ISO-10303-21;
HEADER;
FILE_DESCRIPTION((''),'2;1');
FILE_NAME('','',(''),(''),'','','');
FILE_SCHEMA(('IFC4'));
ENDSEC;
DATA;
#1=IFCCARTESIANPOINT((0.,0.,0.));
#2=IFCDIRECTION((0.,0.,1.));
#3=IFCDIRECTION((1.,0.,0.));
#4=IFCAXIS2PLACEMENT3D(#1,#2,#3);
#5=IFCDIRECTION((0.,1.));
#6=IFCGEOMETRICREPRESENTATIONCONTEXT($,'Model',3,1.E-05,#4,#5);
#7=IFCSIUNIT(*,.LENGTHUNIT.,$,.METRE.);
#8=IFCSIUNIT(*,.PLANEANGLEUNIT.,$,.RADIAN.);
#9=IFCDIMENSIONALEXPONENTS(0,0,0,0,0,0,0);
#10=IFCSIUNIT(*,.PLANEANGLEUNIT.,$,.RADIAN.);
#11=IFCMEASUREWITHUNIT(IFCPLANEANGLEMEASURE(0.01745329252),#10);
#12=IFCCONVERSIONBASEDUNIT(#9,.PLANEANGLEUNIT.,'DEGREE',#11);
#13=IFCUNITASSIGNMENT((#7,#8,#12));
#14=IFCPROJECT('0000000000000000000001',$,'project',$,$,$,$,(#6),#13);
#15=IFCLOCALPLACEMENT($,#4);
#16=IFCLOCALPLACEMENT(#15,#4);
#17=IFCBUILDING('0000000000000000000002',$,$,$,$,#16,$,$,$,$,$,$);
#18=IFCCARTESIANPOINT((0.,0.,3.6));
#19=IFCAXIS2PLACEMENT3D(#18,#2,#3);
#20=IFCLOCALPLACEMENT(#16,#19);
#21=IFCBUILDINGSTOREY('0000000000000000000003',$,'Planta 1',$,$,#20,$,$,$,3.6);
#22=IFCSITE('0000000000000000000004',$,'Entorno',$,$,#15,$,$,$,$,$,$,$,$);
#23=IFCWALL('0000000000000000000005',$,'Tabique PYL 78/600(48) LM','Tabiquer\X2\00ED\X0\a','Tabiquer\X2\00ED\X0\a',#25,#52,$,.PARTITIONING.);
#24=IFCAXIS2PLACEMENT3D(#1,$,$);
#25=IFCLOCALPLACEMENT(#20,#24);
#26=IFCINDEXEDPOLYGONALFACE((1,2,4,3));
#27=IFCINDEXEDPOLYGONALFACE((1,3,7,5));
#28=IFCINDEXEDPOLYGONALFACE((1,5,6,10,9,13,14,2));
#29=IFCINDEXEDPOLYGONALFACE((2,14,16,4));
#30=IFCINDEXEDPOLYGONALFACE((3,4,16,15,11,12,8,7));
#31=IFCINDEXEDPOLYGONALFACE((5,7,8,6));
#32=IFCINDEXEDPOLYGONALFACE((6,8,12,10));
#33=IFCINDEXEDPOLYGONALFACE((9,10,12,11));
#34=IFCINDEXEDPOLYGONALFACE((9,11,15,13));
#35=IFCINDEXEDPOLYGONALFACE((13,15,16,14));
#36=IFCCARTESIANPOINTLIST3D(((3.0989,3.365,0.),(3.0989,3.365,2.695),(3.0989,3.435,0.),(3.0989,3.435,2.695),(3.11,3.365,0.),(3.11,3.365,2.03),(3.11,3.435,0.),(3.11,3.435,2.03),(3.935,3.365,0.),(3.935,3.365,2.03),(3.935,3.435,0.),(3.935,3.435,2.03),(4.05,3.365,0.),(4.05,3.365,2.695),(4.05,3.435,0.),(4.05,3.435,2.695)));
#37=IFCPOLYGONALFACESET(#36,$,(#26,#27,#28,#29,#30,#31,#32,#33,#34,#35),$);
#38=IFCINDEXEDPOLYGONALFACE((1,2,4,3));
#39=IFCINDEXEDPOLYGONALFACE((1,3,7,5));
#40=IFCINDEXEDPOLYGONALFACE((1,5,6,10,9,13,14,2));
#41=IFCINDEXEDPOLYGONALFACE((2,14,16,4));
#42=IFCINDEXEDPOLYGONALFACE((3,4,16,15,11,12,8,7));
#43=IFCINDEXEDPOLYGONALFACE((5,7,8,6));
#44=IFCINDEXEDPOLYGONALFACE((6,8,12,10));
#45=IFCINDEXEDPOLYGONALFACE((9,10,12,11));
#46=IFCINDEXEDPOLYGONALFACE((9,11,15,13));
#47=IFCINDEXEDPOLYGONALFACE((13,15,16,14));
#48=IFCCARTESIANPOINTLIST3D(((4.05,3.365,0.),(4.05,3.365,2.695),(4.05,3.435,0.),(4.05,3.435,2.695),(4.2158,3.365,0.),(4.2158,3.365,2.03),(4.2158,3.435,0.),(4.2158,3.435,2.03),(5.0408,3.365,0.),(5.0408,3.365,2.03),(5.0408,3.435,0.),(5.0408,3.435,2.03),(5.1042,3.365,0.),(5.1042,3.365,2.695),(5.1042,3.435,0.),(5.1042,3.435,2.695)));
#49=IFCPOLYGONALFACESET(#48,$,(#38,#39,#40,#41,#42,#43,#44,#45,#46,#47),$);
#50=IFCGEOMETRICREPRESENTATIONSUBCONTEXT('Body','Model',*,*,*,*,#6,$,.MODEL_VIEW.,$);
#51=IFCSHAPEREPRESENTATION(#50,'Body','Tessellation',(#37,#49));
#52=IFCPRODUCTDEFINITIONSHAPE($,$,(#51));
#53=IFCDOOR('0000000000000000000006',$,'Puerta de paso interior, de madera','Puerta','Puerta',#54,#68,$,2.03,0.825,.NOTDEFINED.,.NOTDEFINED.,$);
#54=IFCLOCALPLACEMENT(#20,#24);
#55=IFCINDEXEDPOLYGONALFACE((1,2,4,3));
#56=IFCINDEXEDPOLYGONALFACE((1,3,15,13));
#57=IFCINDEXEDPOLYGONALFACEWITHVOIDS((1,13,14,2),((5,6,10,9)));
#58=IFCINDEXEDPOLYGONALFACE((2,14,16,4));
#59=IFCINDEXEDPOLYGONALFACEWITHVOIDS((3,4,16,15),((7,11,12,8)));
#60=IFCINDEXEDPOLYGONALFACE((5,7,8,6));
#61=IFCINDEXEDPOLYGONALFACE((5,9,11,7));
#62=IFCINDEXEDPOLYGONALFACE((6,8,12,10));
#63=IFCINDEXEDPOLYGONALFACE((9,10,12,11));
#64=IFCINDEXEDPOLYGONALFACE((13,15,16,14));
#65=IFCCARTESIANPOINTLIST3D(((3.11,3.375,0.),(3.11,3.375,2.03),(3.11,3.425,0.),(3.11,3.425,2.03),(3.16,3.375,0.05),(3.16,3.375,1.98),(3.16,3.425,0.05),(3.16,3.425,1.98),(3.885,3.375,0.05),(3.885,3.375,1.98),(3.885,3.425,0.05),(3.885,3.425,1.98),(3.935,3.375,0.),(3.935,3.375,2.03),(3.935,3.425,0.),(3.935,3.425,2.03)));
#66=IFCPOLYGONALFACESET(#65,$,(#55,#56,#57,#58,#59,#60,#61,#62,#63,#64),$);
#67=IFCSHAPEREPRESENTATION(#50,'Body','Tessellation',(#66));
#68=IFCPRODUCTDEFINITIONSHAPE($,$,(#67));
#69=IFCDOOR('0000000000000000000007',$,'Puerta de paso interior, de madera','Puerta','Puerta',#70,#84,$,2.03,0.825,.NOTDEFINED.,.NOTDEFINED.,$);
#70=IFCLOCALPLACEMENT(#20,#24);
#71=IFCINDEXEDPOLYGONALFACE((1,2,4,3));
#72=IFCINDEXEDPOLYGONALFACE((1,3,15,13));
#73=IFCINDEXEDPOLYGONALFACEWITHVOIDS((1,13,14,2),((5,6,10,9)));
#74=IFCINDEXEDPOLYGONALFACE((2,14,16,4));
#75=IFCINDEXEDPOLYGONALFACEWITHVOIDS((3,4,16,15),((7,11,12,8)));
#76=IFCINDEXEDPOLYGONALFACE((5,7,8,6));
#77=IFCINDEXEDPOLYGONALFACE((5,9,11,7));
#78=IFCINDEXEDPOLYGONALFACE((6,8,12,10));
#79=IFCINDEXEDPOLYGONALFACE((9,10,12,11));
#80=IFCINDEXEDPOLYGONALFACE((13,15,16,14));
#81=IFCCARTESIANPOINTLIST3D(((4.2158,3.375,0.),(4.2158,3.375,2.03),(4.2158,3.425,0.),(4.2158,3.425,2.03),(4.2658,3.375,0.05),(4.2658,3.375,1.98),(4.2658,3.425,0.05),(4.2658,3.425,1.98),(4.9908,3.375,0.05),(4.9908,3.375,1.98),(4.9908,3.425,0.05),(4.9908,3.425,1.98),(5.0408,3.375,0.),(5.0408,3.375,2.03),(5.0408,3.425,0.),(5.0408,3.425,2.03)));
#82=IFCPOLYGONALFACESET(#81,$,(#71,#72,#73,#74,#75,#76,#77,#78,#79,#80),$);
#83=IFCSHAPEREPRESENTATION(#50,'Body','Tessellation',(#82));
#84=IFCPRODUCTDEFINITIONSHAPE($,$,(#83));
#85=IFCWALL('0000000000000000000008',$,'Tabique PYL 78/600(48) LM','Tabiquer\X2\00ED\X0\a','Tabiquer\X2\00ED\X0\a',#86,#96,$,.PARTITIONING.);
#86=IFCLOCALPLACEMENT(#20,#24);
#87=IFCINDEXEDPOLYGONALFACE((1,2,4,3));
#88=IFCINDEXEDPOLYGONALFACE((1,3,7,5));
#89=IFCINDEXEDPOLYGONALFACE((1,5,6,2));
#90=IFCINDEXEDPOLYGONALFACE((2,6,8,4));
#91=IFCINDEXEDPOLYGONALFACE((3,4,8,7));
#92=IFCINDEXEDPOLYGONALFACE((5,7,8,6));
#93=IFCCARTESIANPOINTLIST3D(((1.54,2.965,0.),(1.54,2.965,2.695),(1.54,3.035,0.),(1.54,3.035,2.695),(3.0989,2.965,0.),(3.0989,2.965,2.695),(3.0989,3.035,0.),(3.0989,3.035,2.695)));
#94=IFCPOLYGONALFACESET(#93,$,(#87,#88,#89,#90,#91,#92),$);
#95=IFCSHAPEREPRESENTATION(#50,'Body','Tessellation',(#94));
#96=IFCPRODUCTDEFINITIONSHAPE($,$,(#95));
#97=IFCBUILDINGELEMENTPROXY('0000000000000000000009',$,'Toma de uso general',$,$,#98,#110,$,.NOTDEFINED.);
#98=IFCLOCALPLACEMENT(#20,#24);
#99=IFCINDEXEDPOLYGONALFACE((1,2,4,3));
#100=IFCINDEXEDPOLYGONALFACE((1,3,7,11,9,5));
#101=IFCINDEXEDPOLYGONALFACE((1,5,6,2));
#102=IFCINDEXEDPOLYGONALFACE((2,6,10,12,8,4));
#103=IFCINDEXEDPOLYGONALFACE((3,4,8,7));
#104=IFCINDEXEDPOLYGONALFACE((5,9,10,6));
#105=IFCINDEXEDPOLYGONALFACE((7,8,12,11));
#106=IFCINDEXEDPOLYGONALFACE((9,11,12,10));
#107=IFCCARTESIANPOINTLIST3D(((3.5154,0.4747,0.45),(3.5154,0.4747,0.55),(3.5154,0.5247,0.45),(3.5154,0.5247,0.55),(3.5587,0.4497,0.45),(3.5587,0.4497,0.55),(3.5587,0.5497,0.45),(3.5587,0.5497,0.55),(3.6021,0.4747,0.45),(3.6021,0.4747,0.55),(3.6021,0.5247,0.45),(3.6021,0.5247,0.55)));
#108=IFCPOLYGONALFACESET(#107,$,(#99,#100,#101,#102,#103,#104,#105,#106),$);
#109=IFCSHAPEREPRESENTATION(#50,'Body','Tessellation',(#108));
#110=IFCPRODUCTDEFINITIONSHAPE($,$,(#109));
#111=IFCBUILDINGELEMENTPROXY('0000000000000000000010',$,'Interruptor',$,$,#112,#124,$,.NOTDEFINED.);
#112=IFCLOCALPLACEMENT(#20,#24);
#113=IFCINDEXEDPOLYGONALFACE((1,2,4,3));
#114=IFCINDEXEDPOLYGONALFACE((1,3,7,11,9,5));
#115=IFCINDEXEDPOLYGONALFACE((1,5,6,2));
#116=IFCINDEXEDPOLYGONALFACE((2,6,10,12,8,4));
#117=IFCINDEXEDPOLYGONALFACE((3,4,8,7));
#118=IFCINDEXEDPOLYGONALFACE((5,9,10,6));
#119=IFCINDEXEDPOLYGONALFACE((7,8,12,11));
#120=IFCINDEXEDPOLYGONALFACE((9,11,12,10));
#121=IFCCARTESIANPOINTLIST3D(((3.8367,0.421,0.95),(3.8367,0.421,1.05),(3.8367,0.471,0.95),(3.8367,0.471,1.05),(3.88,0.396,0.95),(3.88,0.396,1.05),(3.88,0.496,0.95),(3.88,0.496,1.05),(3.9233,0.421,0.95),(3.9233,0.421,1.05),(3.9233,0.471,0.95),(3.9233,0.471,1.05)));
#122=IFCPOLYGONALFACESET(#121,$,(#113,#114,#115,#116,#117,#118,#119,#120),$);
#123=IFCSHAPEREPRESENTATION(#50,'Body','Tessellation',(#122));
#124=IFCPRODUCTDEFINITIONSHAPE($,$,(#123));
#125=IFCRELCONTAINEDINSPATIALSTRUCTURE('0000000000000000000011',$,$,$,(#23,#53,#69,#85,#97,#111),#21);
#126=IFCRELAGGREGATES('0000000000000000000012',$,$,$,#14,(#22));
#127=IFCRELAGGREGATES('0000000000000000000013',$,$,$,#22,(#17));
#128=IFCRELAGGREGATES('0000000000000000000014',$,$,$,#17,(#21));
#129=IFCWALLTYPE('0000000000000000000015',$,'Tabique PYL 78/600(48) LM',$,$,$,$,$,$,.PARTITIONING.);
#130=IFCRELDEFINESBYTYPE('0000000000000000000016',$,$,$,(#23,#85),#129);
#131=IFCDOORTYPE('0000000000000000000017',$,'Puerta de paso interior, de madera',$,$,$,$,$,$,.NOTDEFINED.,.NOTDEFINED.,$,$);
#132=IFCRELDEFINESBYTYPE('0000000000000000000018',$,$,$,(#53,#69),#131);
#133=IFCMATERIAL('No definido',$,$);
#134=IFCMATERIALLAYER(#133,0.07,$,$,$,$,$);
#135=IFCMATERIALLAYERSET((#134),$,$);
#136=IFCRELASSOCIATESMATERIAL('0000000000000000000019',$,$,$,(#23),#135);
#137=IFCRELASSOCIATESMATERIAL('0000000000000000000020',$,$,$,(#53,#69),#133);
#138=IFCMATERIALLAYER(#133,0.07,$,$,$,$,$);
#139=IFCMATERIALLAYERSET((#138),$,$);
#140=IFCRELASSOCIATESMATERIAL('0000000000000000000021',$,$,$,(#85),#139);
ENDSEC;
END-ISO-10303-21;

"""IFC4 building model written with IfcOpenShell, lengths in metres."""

from ifc_helpers import new_model, entity, si_unit, converted_unit, direction, frame, origin_with_axes, origin_2d_with_axis, place, context, subcontext, project, spatial, polyline, rectangle, hollow_rectangle, outline, extrude, shape, source, transform, mapped, material, layer, layer_set, layer_usage, type_object, element, fill, save


model = new_model("IFC4")

# Units and contexts
model_context = context("Model", 3, precision=1e-05, world=origin_with_axes(), true_north=direction((0.0, 1.0)))
body_context = subcontext(model_context, "Body", "Model", "MODEL_VIEW")
footprint_context = subcontext(model_context, "FootPrint", "Model", "MODEL_VIEW")
ifc_project = project(units=[si_unit("LENGTHUNIT", "METRE"), si_unit("PLANEANGLEUNIT", "RADIAN"), converted_unit("PLANEANGLEUNIT", "DEGREE", entity("IfcPlaneAngleMeasure", 0.01745329252), si_unit("PLANEANGLEUNIT", "RADIAN"), dimensions=[0, 0, 0, 0, 0, 0, 0])], contexts=[model_context])

# Site, building, storey
site_placement = place(None, origin_with_axes())
site = spatial("IfcSite", under=ifc_project, at=site_placement, Name="Entorno")
building_placement = place(site_placement, origin_with_axes())
building = spatial("IfcBuilding", under=site, at=building_placement)
storey_placement = place(building_placement, frame((0.0, 0.0, 3.6), z_axis=(0.0, 0.0, 1.0), x_axis=(1.0, 0.0, 0.0)))
storey = spatial("IfcBuildingStorey", under=building, at=storey_placement, Name="Planta 1", Elevation=3.6)

# Shared definitions
ifc_material = material(Name="No definido")

# Shared definitions
wall_type_1 = type_object("IfcWallType", Name="Tabique PYL 78/600(48) LM", PredefinedType="PARTITIONING")
door_type = type_object("IfcDoorType", Name="Puerta de paso interior, de madera", OperationType="NOTDEFINED", PredefinedType="NOTDEFINED")

# Wall, openings, doors
ifc_layer_1 = layer(ifc_material, 0.07)
ifc_layer_set_1 = layer_set([ifc_layer_1])
ifc_layer_usage_1 = layer_usage(ifc_layer_set_1, "AXIS2", "POSITIVE", -0.035)
wall_1_placement = place(storey_placement, frame((3.0639, 3.4, 0.0), z_axis=(0.0, 0.0, 1.0), x_axis=(1.0, 0.0, 0.0)))
cartesian_point_1 = entity("IfcCartesianPoint", [-0.4755, -1.3475])
cartesian_point_2 = entity("IfcCartesianPoint", [-0.4755, -1.3475])
cartesian_point_3 = entity("IfcCartesianPoint", [-0.5271, -1.3475])
cartesian_point_4 = entity("IfcCartesianPoint", [-0.5271, -1.3475])
wall_1 = element("IfcWall", 1, at=wall_1_placement, inside=storey, type_object=wall_type_1, material=ifc_layer_usage_1, Name="Tabique PYL 78/600(48) LM", Description="Tabiquería", ObjectType="Tabiquería", PredefinedType="PARTITIONING", context=body_context, shape_type="SolidModel", body=[
    entity("IfcExtrudedAreaSolidTapered", entity("IfcArbitraryClosedProfileDef", "AREA", None, entity("IfcPolyline", [cartesian_point_1, entity("IfcCartesianPoint", [0.4755, -1.3475]), entity("IfcCartesianPoint", [0.4755, 1.3475]), entity("IfcCartesianPoint", [-0.4755, 1.3475]), cartesian_point_1])), entity("IfcAxis2Placement3D", entity("IfcCartesianPoint", [0.5106, 0.035, 1.3475]), entity("IfcDirection", [0.0, -1.0, 0.0]), entity("IfcDirection", [1.0, 0.0, 0.0])), entity("IfcDirection", [0.0, 0.0, 1.0]), 0.07, entity("IfcArbitraryClosedProfileDef", "AREA", None, entity("IfcPolyline", [cartesian_point_2, entity("IfcCartesianPoint", [0.4755, -1.3475]), entity("IfcCartesianPoint", [0.4755, 1.3475]), entity("IfcCartesianPoint", [-0.4755, 1.3475]), cartesian_point_2]))),
    entity("IfcExtrudedAreaSolidTapered", entity("IfcArbitraryClosedProfileDef", "AREA", None, entity("IfcPolyline", [cartesian_point_3, entity("IfcCartesianPoint", [0.5271, -1.3475]), entity("IfcCartesianPoint", [0.5271, 1.3475]), entity("IfcCartesianPoint", [-0.5271, 1.3475]), cartesian_point_3])), entity("IfcAxis2Placement3D", entity("IfcCartesianPoint", [1.5132, 0.035, 1.3475]), entity("IfcDirection", [0.0, -1.0, 0.0]), entity("IfcDirection", [1.0, 0.0, 0.0])), entity("IfcDirection", [0.0, 0.0, 1.0]), 0.07, entity("IfcArbitraryClosedProfileDef", "AREA", None, entity("IfcPolyline", [cartesian_point_4, entity("IfcCartesianPoint", [0.5271, -1.3475]), entity("IfcCartesianPoint", [0.5271, 1.3475]), entity("IfcCartesianPoint", [-0.5271, 1.3475]), cartesian_point_4]))),
])
opening_1_placement = place(wall_1_placement, frame((0.4586, 0.0, 1.015), z_axis=(0.0, 0.0, 1.0), x_axis=(1.0, 0.0, 0.0)))
cartesian_point_5 = entity("IfcCartesianPoint", [-0.4125, -0.035])
opening_1 = element("IfcOpeningElement", 2, at=opening_1_placement, cuts=wall_1, ObjectType="No definido", PredefinedType="OPENING", shapes=[
    shape(body_context, "Body", "SweptSolid", [extrude(rectangle(XDim=2.03, YDim=0.825, at=origin_2d_with_axis()), frame((0.0, -0.035, 0.0), z_axis=(0.0, 1.0, 0.0), x_axis=(0.0, 0.0, 1.0)), (0.0, 0.0, 1.0), 0.07)]),
    shape(footprint_context, "FootPrint", "GeometricCurveSet", [entity("IfcGeometricCurveSet", [entity("IfcPolyline", [cartesian_point_5, entity("IfcCartesianPoint", [0.4125, -0.035]), entity("IfcCartesianPoint", [0.4125, 0.035]), entity("IfcCartesianPoint", [-0.4125, 0.035]), cartesian_point_5])])]),
])
opening_2_placement = place(wall_1_placement, frame((1.5644, 0.0, 1.015), z_axis=(0.0, 0.0, 1.0), x_axis=(1.0, 0.0, 0.0)))
cartesian_point_6 = entity("IfcCartesianPoint", [-0.4125, -0.035])
opening_2 = element("IfcOpeningElement", 3, at=opening_2_placement, cuts=wall_1, ObjectType="No definido", PredefinedType="OPENING", shapes=[
    shape(body_context, "Body", "SweptSolid", [extrude(rectangle(XDim=2.03, YDim=0.825, at=origin_2d_with_axis()), frame((0.0, -0.035, 0.0), z_axis=(0.0, 1.0, 0.0), x_axis=(0.0, 0.0, 1.0)), (0.0, 0.0, 1.0), 0.07)]),
    shape(footprint_context, "FootPrint", "GeometricCurveSet", [entity("IfcGeometricCurveSet", [entity("IfcPolyline", [cartesian_point_6, entity("IfcCartesianPoint", [0.4125, -0.035]), entity("IfcCartesianPoint", [0.4125, 0.035]), entity("IfcCartesianPoint", [-0.4125, 0.035]), cartesian_point_6])])]),
])
door_1_placement = place(opening_1_placement, origin_with_axes())
door_1 = element("IfcDoor", 4, at=door_1_placement, inside=storey, type_object=door_type, material=ifc_material, Name="Puerta de paso interior, de madera", Description="Puerta", ObjectType="Puerta", OperationType="NOTDEFINED", OverallHeight=2.03, OverallWidth=0.825, PredefinedType="NOTDEFINED", context=body_context, shape_type="SweptSolid", body=[
    extrude(hollow_rectangle(XDim=0.825, YDim=2.03, WallThickness=0.05, InnerFilletRadius=0.0, OuterFilletRadius=0.0, at=origin_2d_with_axis()), frame((0.0, 0.025, 0.0), z_axis=(0.0, -1.0, 0.0), x_axis=(1.0, 0.0, 0.0)), (0.0, 0.0, 1.0), 0.05),
])
fill(opening_1, door_1)
door_2_placement = place(opening_2_placement, origin_with_axes())
door_2 = element("IfcDoor", 5, at=door_2_placement, inside=storey, type_object=door_type, material=ifc_material, Name="Puerta de paso interior, de madera", Description="Puerta", ObjectType="Puerta", OperationType="NOTDEFINED", OverallHeight=2.03, OverallWidth=0.825, PredefinedType="NOTDEFINED", context=body_context, shape_type="SweptSolid", body=[
    extrude(hollow_rectangle(XDim=0.825, YDim=2.03, WallThickness=0.05, InnerFilletRadius=0.0, OuterFilletRadius=0.0, at=origin_2d_with_axis()), frame((0.0, 0.025, 0.0), z_axis=(0.0, -1.0, 0.0), x_axis=(1.0, 0.0, 0.0)), (0.0, 0.0, 1.0), 0.05),
])
fill(opening_2, door_2)

# Wall
ifc_layer_2 = layer(ifc_material, 0.07)
ifc_layer_set_2 = layer_set([ifc_layer_2])
ifc_layer_usage_2 = layer_usage(ifc_layer_set_2, "AXIS2", "POSITIVE", -0.035)
wall_2_placement = place(storey_placement, frame((1.575, 3.0, 0.0), z_axis=(0.0, 0.0, 1.0), x_axis=(1.0, 0.0, 0.0)))
cartesian_point_7 = entity("IfcCartesianPoint", [-0.7794, -1.3475])
cartesian_point_8 = entity("IfcCartesianPoint", [-0.7794, -1.3475])
element("IfcWall", 6, at=wall_2_placement, inside=storey, type_object=wall_type_1, material=ifc_layer_usage_2, Name="Tabique PYL 78/600(48) LM", Description="Tabiquería", ObjectType="Tabiquería", PredefinedType="PARTITIONING", context=body_context, shape_type="SolidModel", body=[
    entity("IfcExtrudedAreaSolidTapered", entity("IfcArbitraryClosedProfileDef", "AREA", None, entity("IfcPolyline", [cartesian_point_7, entity("IfcCartesianPoint", [0.7794, -1.3475]), entity("IfcCartesianPoint", [0.7794, 1.3475]), entity("IfcCartesianPoint", [-0.7794, 1.3475]), cartesian_point_7])), entity("IfcAxis2Placement3D", entity("IfcCartesianPoint", [0.7445, 0.035, 1.3475]), entity("IfcDirection", [0.0, -1.0, 0.0]), entity("IfcDirection", [1.0, 0.0, 0.0])), entity("IfcDirection", [0.0, 0.0, 1.0]), 0.07, entity("IfcArbitraryClosedProfileDef", "AREA", None, entity("IfcPolyline", [cartesian_point_8, entity("IfcCartesianPoint", [0.7794, -1.3475]), entity("IfcCartesianPoint", [0.7794, 1.3475]), entity("IfcCartesianPoint", [-0.7794, 1.3475]), cartesian_point_8]))),
])

# Building element proxies
shared_shape_1 = source(origin_with_axes(), body_context, "Body", "SolidModel", [
    extrude(outline(polyline([(0.05, 0.0), (0.025, 0.0433), (-0.025, 0.0433), (-0.05, 0.0), (-0.025, -0.0433), (0.025, -0.0433), (0.05, 0.0)])), frame((0.0, 0.0, -0.05), z_axis=(0.0, 0.0, 1.0), x_axis=(1.0, 0.0, 0.0)), (0.0, 0.0, 1.0), 0.1),
])
proxy_1_placement = place(storey_placement, frame((0.0, 0.0, -3.6), z_axis=(0.0, 0.0, 1.0), x_axis=(1.0, 0.0, 0.0)))
element("IfcBuildingElementProxy", 7, at=proxy_1_placement, inside=storey, Name="Toma de uso general", PredefinedType="NOTDEFINED", context=body_context, shape_type="Brep", body=[
    mapped(shared_shape_1, transform((3.5587, 0.4997, 4.1), x_axis=(0.0, 1.0, 0.0), y_axis=(-1.0, 0.0, 0.0), z_axis=(0.0, 0.0, 1.0))),
])
shared_shape_2 = source(origin_with_axes(), body_context, "Body", "SolidModel", [
    extrude(outline(polyline([(0.05, 0.0), (0.025, 0.0433), (-0.025, 0.0433), (-0.05, 0.0), (-0.025, -0.0433), (0.025, -0.0433), (0.05, 0.0)])), frame((0.0, 0.0, -0.05), z_axis=(0.0, 0.0, 1.0), x_axis=(1.0, 0.0, 0.0)), (0.0, 0.0, 1.0), 0.1),
])
proxy_2_placement = place(storey_placement, frame((0.0, 0.0, -3.6), z_axis=(0.0, 0.0, 1.0), x_axis=(1.0, 0.0, 0.0)))
element("IfcBuildingElementProxy", 8, at=proxy_2_placement, inside=storey, Name="Interruptor", PredefinedType="NOTDEFINED", context=body_context, shape_type="Brep", body=[
    mapped(shared_shape_2, transform((3.88, 0.446, 4.6), x_axis=(0.0, 1.0, 0.0), y_axis=(-1.0, 0.0, 0.0), z_axis=(0.0, 0.0, 1.0))),
])

save(model, "model.ifc")
